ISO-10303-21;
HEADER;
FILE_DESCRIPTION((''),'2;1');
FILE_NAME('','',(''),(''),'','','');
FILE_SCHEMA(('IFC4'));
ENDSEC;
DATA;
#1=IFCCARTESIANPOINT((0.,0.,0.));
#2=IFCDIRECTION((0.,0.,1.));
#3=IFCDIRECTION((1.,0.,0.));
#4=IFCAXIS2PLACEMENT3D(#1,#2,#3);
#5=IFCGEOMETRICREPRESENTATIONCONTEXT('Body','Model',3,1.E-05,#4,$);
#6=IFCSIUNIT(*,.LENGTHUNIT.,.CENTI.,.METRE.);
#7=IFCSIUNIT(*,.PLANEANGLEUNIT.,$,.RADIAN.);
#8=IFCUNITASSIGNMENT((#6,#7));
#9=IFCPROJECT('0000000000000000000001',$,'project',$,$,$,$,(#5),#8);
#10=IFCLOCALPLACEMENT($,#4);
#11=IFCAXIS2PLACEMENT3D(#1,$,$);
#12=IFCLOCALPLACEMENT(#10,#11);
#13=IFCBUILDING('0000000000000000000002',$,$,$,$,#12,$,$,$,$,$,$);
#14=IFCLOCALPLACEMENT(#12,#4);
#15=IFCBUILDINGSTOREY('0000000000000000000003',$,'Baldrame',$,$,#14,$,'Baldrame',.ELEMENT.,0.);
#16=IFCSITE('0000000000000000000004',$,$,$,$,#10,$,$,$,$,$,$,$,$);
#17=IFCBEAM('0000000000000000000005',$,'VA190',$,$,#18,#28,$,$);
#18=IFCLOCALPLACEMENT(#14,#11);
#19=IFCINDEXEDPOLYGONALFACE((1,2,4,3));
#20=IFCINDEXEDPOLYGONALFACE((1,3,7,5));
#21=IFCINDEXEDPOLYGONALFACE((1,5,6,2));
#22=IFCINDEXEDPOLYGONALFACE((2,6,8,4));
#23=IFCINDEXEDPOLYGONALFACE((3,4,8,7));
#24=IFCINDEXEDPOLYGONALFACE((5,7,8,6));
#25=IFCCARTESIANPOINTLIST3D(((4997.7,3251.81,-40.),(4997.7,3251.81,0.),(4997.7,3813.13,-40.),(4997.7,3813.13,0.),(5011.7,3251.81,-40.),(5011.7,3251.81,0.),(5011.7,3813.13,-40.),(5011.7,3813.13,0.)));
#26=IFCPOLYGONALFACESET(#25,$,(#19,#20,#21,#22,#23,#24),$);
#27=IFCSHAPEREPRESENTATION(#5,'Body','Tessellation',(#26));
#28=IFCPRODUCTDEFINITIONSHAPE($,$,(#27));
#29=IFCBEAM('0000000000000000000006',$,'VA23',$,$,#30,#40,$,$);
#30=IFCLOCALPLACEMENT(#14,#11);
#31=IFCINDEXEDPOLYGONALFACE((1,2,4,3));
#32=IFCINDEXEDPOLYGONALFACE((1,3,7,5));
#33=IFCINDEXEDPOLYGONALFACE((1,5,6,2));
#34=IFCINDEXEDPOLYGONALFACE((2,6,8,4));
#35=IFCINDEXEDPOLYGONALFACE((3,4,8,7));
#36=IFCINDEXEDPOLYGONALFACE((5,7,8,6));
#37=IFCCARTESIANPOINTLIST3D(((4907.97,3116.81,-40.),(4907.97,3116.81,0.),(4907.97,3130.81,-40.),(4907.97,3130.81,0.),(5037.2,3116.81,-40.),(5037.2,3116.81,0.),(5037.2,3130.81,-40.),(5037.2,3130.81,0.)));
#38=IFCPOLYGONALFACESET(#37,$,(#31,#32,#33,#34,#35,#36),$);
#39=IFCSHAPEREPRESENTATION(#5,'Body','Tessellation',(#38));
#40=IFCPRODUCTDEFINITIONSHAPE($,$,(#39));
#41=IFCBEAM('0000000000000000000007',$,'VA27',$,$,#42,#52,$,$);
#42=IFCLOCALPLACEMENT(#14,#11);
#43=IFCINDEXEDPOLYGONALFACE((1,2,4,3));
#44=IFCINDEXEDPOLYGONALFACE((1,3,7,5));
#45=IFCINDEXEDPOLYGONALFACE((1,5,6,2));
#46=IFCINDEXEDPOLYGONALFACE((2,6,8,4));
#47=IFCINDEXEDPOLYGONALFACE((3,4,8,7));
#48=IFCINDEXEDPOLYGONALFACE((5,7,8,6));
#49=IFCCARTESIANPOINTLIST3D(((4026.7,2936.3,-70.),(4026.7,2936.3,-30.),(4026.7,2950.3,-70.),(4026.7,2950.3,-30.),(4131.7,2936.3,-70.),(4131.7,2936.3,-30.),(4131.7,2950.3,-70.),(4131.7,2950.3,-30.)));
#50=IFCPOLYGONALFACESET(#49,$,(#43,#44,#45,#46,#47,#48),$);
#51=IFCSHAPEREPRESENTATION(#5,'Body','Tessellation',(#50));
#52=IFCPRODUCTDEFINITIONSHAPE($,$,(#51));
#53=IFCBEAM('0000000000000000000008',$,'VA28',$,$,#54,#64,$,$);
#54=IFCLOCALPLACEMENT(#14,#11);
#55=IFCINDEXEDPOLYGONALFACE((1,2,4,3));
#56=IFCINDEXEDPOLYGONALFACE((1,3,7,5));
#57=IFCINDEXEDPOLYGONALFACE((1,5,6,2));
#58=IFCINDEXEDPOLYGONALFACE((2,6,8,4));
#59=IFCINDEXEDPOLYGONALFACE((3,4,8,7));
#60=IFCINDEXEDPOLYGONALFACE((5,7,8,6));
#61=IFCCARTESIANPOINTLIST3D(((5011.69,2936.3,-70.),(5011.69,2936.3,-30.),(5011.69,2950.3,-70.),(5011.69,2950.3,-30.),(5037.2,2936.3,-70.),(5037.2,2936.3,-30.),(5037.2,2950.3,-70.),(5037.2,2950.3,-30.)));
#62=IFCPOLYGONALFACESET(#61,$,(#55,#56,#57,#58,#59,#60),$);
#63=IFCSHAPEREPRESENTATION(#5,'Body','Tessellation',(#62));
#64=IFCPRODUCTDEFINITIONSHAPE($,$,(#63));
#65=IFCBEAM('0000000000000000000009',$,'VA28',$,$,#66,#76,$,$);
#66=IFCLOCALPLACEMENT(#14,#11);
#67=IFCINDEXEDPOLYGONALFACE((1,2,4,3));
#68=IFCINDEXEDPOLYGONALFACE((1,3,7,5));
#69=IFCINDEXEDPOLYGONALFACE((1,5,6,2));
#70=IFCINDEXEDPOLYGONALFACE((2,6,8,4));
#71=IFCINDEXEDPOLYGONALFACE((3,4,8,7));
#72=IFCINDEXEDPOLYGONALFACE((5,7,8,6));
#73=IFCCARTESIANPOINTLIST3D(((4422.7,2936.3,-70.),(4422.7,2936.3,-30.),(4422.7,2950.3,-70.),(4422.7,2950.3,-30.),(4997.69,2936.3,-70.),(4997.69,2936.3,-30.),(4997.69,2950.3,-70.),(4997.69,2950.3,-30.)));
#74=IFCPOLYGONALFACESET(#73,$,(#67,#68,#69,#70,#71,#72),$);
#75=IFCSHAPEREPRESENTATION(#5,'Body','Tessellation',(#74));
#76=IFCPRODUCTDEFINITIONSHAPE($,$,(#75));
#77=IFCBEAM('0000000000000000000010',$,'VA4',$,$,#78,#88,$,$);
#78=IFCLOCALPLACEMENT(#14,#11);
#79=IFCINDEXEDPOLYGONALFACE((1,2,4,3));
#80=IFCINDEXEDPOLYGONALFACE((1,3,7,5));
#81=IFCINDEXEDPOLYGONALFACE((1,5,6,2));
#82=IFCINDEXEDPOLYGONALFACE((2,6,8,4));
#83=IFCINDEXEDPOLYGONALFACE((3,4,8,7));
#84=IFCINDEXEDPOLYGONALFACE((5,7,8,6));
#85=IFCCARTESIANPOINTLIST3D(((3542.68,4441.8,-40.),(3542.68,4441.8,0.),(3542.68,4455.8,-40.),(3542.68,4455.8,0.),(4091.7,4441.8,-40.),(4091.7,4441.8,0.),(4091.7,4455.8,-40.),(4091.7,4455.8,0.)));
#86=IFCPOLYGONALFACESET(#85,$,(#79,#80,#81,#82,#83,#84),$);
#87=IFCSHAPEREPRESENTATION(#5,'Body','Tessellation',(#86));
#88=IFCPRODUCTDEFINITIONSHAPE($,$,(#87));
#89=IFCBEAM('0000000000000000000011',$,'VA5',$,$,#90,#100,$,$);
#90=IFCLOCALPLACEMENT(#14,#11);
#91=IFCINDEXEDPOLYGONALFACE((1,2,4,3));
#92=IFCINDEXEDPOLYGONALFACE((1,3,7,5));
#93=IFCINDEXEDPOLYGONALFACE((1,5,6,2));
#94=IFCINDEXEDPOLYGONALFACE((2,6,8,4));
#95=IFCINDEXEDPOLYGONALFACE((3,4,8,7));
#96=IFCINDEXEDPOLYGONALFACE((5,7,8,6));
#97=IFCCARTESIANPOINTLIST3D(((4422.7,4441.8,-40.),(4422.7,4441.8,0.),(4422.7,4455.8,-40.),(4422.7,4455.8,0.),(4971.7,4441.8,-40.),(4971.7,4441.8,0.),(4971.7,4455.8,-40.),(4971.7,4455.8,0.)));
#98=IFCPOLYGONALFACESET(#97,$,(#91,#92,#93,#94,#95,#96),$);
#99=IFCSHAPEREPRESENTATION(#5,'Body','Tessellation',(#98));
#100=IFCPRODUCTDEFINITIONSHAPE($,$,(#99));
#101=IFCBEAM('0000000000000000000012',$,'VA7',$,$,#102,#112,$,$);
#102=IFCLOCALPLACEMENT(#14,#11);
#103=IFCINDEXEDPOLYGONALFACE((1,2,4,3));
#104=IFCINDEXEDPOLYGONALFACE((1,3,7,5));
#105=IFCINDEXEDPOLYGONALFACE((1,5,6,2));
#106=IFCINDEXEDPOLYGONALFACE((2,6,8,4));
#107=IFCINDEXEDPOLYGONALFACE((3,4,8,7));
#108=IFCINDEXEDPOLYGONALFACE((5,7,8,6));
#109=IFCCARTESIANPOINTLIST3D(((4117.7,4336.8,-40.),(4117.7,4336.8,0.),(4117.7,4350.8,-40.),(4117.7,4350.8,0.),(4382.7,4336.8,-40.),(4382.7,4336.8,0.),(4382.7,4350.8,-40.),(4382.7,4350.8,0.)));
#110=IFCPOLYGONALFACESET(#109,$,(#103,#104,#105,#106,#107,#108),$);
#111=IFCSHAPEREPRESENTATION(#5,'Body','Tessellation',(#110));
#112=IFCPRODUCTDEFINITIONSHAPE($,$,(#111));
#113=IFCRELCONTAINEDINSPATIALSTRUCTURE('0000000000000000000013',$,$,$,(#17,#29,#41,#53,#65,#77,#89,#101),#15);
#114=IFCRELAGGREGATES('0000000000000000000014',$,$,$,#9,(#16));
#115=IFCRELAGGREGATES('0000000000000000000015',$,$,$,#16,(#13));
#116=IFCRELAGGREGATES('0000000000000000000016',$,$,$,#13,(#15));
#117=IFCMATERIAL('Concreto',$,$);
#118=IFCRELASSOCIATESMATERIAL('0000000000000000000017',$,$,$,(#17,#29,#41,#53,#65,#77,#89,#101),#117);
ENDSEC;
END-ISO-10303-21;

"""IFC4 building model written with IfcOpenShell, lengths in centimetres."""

from ifc_helpers import new_model, si_unit, frame, origin, origin_with_axes, origin_2d_with_axis, place, context, project, spatial, rectangle, extrude, material, element, save


model = new_model("IFC4")

# Units and contexts
model_context = context("Model", 3, precision=1e-05, world=origin_with_axes(), identifier="Body")
ifc_project = project(units=[si_unit("LENGTHUNIT", "METRE", prefix="CENTI"), si_unit("PLANEANGLEUNIT", "RADIAN")], contexts=[model_context])

# Site, building, storey
site_placement = place(None, origin_with_axes())
site = spatial("IfcSite", under=ifc_project, at=site_placement)
building_placement = place(site_placement, origin())
building = spatial("IfcBuilding", under=site, at=building_placement)
storey_placement = place(building_placement, origin_with_axes())
storey = spatial("IfcBuildingStorey", under=building, at=storey_placement, Name="Baldrame", LongName="Baldrame", CompositionType="ELEMENT", Elevation=0.0)

# Shared definitions
ifc_material = material(Name="Concreto")

# Beams
beam_1_placement = place(storey_placement, frame((5004.7, 3532.47, 0.0), z_axis=(0.0, 0.0, 1.0), x_axis=(1.0, 0.0, 0.0)))
element("IfcBeam", 1, at=beam_1_placement, inside=storey, material=ifc_material, Name="VA190", context=model_context, shape_type="SolidModel", body=[
    extrude(rectangle(XDim=14.0, YDim=40.0, at=origin_2d_with_axis()), frame((0.0, -280.66, -20.0), z_axis=(0.0, 1.0, 0.0), x_axis=(1.0, 0.0, 0.0)), (0.0, 0.0, 1.0), 561.32),
])
beam_2_placement = place(storey_placement, frame((4972.58, 3123.81, 0.0), z_axis=(0.0, 0.0, 1.0), x_axis=(1.0, 0.0, 0.0)))
element("IfcBeam", 2, at=beam_2_placement, inside=storey, material=ifc_material, Name="VA23", context=model_context, shape_type="SolidModel", body=[
    extrude(rectangle(XDim=14.0, YDim=40.0, at=origin_2d_with_axis()), frame((-64.62, 0.0, -20.0), z_axis=(1.0, 0.0, 0.0), x_axis=(0.0, 1.0, 0.0)), (0.0, 0.0, 1.0), 129.23),
])
beam_3_placement = place(storey_placement, frame((4079.2, 2943.3, -30.0), z_axis=(0.0, 0.0, 1.0), x_axis=(1.0, 0.0, 0.0)))
element("IfcBeam", 3, at=beam_3_placement, inside=storey, material=ifc_material, Name="VA27", context=model_context, shape_type="SolidModel", body=[
    extrude(rectangle(XDim=14.0, YDim=40.0, at=origin_2d_with_axis()), frame((-52.5, 0.0, -20.0), z_axis=(1.0, 0.0, 0.0), x_axis=(0.0, 1.0, 0.0)), (0.0, 0.0, 1.0), 105.0),
])
beam_4_placement = place(storey_placement, frame((5024.44, 2943.3, -30.0), z_axis=(0.0, 0.0, 1.0), x_axis=(1.0, 0.0, 0.0)))
element("IfcBeam", 4, at=beam_4_placement, inside=storey, material=ifc_material, Name="VA28", context=model_context, shape_type="SolidModel", body=[
    extrude(rectangle(XDim=14.0, YDim=40.0, at=origin_2d_with_axis()), frame((-12.76, 0.0, -20.0), z_axis=(1.0, 0.0, 0.0), x_axis=(0.0, 1.0, 0.0)), (0.0, 0.0, 1.0), 25.51),
])
beam_5_placement = place(storey_placement, frame((4710.19, 2943.3, -30.0), z_axis=(0.0, 0.0, 1.0), x_axis=(1.0, 0.0, 0.0)))
element("IfcBeam", 5, at=beam_5_placement, inside=storey, material=ifc_material, Name="VA28", context=model_context, shape_type="SolidModel", body=[
    extrude(rectangle(XDim=14.0, YDim=40.0, at=origin_2d_with_axis()), frame((-287.5, 0.0, -20.0), z_axis=(1.0, 0.0, 0.0), x_axis=(0.0, 1.0, 0.0)), (0.0, 0.0, 1.0), 574.99),
])
beam_6_placement = place(storey_placement, frame((3817.19, 4448.8, 0.0), z_axis=(0.0, 0.0, 1.0), x_axis=(1.0, 0.0, 0.0)))
element("IfcBeam", 6, at=beam_6_placement, inside=storey, material=ifc_material, Name="VA4", context=model_context, shape_type="SolidModel", body=[
    extrude(rectangle(XDim=14.0, YDim=40.0, at=origin_2d_with_axis()), frame((-274.51, 0.0, -20.0), z_axis=(1.0, 0.0, 0.0), x_axis=(0.0, 1.0, 0.0)), (0.0, 0.0, 1.0), 549.02),
])
beam_7_placement = place(storey_placement, frame((4697.2, 4448.8, 0.0), z_axis=(0.0, 0.0, 1.0), x_axis=(1.0, 0.0, 0.0)))
element("IfcBeam", 7, at=beam_7_placement, inside=storey, material=ifc_material, Name="VA5", context=model_context, shape_type="SolidModel", body=[
    extrude(rectangle(XDim=14.0, YDim=40.0, at=origin_2d_with_axis()), frame((-274.5, 0.0, -20.0), z_axis=(1.0, 0.0, 0.0), x_axis=(0.0, 1.0, 0.0)), (0.0, 0.0, 1.0), 549.0),
])
beam_8_placement = place(storey_placement, frame((4250.2, 4343.8, 0.0), z_axis=(0.0, 0.0, 1.0), x_axis=(1.0, 0.0, 0.0)))
element("IfcBeam", 8, at=beam_8_placement, inside=storey, material=ifc_material, Name="VA7", context=model_context, shape_type="SolidModel", body=[
    extrude(rectangle(XDim=14.0, YDim=40.0, at=origin_2d_with_axis()), frame((-132.5, 0.0, -20.0), z_axis=(1.0, 0.0, 0.0), x_axis=(0.0, 1.0, 0.0)), (0.0, 0.0, 1.0), 265.0),
])

save(model, "model.ifc")
